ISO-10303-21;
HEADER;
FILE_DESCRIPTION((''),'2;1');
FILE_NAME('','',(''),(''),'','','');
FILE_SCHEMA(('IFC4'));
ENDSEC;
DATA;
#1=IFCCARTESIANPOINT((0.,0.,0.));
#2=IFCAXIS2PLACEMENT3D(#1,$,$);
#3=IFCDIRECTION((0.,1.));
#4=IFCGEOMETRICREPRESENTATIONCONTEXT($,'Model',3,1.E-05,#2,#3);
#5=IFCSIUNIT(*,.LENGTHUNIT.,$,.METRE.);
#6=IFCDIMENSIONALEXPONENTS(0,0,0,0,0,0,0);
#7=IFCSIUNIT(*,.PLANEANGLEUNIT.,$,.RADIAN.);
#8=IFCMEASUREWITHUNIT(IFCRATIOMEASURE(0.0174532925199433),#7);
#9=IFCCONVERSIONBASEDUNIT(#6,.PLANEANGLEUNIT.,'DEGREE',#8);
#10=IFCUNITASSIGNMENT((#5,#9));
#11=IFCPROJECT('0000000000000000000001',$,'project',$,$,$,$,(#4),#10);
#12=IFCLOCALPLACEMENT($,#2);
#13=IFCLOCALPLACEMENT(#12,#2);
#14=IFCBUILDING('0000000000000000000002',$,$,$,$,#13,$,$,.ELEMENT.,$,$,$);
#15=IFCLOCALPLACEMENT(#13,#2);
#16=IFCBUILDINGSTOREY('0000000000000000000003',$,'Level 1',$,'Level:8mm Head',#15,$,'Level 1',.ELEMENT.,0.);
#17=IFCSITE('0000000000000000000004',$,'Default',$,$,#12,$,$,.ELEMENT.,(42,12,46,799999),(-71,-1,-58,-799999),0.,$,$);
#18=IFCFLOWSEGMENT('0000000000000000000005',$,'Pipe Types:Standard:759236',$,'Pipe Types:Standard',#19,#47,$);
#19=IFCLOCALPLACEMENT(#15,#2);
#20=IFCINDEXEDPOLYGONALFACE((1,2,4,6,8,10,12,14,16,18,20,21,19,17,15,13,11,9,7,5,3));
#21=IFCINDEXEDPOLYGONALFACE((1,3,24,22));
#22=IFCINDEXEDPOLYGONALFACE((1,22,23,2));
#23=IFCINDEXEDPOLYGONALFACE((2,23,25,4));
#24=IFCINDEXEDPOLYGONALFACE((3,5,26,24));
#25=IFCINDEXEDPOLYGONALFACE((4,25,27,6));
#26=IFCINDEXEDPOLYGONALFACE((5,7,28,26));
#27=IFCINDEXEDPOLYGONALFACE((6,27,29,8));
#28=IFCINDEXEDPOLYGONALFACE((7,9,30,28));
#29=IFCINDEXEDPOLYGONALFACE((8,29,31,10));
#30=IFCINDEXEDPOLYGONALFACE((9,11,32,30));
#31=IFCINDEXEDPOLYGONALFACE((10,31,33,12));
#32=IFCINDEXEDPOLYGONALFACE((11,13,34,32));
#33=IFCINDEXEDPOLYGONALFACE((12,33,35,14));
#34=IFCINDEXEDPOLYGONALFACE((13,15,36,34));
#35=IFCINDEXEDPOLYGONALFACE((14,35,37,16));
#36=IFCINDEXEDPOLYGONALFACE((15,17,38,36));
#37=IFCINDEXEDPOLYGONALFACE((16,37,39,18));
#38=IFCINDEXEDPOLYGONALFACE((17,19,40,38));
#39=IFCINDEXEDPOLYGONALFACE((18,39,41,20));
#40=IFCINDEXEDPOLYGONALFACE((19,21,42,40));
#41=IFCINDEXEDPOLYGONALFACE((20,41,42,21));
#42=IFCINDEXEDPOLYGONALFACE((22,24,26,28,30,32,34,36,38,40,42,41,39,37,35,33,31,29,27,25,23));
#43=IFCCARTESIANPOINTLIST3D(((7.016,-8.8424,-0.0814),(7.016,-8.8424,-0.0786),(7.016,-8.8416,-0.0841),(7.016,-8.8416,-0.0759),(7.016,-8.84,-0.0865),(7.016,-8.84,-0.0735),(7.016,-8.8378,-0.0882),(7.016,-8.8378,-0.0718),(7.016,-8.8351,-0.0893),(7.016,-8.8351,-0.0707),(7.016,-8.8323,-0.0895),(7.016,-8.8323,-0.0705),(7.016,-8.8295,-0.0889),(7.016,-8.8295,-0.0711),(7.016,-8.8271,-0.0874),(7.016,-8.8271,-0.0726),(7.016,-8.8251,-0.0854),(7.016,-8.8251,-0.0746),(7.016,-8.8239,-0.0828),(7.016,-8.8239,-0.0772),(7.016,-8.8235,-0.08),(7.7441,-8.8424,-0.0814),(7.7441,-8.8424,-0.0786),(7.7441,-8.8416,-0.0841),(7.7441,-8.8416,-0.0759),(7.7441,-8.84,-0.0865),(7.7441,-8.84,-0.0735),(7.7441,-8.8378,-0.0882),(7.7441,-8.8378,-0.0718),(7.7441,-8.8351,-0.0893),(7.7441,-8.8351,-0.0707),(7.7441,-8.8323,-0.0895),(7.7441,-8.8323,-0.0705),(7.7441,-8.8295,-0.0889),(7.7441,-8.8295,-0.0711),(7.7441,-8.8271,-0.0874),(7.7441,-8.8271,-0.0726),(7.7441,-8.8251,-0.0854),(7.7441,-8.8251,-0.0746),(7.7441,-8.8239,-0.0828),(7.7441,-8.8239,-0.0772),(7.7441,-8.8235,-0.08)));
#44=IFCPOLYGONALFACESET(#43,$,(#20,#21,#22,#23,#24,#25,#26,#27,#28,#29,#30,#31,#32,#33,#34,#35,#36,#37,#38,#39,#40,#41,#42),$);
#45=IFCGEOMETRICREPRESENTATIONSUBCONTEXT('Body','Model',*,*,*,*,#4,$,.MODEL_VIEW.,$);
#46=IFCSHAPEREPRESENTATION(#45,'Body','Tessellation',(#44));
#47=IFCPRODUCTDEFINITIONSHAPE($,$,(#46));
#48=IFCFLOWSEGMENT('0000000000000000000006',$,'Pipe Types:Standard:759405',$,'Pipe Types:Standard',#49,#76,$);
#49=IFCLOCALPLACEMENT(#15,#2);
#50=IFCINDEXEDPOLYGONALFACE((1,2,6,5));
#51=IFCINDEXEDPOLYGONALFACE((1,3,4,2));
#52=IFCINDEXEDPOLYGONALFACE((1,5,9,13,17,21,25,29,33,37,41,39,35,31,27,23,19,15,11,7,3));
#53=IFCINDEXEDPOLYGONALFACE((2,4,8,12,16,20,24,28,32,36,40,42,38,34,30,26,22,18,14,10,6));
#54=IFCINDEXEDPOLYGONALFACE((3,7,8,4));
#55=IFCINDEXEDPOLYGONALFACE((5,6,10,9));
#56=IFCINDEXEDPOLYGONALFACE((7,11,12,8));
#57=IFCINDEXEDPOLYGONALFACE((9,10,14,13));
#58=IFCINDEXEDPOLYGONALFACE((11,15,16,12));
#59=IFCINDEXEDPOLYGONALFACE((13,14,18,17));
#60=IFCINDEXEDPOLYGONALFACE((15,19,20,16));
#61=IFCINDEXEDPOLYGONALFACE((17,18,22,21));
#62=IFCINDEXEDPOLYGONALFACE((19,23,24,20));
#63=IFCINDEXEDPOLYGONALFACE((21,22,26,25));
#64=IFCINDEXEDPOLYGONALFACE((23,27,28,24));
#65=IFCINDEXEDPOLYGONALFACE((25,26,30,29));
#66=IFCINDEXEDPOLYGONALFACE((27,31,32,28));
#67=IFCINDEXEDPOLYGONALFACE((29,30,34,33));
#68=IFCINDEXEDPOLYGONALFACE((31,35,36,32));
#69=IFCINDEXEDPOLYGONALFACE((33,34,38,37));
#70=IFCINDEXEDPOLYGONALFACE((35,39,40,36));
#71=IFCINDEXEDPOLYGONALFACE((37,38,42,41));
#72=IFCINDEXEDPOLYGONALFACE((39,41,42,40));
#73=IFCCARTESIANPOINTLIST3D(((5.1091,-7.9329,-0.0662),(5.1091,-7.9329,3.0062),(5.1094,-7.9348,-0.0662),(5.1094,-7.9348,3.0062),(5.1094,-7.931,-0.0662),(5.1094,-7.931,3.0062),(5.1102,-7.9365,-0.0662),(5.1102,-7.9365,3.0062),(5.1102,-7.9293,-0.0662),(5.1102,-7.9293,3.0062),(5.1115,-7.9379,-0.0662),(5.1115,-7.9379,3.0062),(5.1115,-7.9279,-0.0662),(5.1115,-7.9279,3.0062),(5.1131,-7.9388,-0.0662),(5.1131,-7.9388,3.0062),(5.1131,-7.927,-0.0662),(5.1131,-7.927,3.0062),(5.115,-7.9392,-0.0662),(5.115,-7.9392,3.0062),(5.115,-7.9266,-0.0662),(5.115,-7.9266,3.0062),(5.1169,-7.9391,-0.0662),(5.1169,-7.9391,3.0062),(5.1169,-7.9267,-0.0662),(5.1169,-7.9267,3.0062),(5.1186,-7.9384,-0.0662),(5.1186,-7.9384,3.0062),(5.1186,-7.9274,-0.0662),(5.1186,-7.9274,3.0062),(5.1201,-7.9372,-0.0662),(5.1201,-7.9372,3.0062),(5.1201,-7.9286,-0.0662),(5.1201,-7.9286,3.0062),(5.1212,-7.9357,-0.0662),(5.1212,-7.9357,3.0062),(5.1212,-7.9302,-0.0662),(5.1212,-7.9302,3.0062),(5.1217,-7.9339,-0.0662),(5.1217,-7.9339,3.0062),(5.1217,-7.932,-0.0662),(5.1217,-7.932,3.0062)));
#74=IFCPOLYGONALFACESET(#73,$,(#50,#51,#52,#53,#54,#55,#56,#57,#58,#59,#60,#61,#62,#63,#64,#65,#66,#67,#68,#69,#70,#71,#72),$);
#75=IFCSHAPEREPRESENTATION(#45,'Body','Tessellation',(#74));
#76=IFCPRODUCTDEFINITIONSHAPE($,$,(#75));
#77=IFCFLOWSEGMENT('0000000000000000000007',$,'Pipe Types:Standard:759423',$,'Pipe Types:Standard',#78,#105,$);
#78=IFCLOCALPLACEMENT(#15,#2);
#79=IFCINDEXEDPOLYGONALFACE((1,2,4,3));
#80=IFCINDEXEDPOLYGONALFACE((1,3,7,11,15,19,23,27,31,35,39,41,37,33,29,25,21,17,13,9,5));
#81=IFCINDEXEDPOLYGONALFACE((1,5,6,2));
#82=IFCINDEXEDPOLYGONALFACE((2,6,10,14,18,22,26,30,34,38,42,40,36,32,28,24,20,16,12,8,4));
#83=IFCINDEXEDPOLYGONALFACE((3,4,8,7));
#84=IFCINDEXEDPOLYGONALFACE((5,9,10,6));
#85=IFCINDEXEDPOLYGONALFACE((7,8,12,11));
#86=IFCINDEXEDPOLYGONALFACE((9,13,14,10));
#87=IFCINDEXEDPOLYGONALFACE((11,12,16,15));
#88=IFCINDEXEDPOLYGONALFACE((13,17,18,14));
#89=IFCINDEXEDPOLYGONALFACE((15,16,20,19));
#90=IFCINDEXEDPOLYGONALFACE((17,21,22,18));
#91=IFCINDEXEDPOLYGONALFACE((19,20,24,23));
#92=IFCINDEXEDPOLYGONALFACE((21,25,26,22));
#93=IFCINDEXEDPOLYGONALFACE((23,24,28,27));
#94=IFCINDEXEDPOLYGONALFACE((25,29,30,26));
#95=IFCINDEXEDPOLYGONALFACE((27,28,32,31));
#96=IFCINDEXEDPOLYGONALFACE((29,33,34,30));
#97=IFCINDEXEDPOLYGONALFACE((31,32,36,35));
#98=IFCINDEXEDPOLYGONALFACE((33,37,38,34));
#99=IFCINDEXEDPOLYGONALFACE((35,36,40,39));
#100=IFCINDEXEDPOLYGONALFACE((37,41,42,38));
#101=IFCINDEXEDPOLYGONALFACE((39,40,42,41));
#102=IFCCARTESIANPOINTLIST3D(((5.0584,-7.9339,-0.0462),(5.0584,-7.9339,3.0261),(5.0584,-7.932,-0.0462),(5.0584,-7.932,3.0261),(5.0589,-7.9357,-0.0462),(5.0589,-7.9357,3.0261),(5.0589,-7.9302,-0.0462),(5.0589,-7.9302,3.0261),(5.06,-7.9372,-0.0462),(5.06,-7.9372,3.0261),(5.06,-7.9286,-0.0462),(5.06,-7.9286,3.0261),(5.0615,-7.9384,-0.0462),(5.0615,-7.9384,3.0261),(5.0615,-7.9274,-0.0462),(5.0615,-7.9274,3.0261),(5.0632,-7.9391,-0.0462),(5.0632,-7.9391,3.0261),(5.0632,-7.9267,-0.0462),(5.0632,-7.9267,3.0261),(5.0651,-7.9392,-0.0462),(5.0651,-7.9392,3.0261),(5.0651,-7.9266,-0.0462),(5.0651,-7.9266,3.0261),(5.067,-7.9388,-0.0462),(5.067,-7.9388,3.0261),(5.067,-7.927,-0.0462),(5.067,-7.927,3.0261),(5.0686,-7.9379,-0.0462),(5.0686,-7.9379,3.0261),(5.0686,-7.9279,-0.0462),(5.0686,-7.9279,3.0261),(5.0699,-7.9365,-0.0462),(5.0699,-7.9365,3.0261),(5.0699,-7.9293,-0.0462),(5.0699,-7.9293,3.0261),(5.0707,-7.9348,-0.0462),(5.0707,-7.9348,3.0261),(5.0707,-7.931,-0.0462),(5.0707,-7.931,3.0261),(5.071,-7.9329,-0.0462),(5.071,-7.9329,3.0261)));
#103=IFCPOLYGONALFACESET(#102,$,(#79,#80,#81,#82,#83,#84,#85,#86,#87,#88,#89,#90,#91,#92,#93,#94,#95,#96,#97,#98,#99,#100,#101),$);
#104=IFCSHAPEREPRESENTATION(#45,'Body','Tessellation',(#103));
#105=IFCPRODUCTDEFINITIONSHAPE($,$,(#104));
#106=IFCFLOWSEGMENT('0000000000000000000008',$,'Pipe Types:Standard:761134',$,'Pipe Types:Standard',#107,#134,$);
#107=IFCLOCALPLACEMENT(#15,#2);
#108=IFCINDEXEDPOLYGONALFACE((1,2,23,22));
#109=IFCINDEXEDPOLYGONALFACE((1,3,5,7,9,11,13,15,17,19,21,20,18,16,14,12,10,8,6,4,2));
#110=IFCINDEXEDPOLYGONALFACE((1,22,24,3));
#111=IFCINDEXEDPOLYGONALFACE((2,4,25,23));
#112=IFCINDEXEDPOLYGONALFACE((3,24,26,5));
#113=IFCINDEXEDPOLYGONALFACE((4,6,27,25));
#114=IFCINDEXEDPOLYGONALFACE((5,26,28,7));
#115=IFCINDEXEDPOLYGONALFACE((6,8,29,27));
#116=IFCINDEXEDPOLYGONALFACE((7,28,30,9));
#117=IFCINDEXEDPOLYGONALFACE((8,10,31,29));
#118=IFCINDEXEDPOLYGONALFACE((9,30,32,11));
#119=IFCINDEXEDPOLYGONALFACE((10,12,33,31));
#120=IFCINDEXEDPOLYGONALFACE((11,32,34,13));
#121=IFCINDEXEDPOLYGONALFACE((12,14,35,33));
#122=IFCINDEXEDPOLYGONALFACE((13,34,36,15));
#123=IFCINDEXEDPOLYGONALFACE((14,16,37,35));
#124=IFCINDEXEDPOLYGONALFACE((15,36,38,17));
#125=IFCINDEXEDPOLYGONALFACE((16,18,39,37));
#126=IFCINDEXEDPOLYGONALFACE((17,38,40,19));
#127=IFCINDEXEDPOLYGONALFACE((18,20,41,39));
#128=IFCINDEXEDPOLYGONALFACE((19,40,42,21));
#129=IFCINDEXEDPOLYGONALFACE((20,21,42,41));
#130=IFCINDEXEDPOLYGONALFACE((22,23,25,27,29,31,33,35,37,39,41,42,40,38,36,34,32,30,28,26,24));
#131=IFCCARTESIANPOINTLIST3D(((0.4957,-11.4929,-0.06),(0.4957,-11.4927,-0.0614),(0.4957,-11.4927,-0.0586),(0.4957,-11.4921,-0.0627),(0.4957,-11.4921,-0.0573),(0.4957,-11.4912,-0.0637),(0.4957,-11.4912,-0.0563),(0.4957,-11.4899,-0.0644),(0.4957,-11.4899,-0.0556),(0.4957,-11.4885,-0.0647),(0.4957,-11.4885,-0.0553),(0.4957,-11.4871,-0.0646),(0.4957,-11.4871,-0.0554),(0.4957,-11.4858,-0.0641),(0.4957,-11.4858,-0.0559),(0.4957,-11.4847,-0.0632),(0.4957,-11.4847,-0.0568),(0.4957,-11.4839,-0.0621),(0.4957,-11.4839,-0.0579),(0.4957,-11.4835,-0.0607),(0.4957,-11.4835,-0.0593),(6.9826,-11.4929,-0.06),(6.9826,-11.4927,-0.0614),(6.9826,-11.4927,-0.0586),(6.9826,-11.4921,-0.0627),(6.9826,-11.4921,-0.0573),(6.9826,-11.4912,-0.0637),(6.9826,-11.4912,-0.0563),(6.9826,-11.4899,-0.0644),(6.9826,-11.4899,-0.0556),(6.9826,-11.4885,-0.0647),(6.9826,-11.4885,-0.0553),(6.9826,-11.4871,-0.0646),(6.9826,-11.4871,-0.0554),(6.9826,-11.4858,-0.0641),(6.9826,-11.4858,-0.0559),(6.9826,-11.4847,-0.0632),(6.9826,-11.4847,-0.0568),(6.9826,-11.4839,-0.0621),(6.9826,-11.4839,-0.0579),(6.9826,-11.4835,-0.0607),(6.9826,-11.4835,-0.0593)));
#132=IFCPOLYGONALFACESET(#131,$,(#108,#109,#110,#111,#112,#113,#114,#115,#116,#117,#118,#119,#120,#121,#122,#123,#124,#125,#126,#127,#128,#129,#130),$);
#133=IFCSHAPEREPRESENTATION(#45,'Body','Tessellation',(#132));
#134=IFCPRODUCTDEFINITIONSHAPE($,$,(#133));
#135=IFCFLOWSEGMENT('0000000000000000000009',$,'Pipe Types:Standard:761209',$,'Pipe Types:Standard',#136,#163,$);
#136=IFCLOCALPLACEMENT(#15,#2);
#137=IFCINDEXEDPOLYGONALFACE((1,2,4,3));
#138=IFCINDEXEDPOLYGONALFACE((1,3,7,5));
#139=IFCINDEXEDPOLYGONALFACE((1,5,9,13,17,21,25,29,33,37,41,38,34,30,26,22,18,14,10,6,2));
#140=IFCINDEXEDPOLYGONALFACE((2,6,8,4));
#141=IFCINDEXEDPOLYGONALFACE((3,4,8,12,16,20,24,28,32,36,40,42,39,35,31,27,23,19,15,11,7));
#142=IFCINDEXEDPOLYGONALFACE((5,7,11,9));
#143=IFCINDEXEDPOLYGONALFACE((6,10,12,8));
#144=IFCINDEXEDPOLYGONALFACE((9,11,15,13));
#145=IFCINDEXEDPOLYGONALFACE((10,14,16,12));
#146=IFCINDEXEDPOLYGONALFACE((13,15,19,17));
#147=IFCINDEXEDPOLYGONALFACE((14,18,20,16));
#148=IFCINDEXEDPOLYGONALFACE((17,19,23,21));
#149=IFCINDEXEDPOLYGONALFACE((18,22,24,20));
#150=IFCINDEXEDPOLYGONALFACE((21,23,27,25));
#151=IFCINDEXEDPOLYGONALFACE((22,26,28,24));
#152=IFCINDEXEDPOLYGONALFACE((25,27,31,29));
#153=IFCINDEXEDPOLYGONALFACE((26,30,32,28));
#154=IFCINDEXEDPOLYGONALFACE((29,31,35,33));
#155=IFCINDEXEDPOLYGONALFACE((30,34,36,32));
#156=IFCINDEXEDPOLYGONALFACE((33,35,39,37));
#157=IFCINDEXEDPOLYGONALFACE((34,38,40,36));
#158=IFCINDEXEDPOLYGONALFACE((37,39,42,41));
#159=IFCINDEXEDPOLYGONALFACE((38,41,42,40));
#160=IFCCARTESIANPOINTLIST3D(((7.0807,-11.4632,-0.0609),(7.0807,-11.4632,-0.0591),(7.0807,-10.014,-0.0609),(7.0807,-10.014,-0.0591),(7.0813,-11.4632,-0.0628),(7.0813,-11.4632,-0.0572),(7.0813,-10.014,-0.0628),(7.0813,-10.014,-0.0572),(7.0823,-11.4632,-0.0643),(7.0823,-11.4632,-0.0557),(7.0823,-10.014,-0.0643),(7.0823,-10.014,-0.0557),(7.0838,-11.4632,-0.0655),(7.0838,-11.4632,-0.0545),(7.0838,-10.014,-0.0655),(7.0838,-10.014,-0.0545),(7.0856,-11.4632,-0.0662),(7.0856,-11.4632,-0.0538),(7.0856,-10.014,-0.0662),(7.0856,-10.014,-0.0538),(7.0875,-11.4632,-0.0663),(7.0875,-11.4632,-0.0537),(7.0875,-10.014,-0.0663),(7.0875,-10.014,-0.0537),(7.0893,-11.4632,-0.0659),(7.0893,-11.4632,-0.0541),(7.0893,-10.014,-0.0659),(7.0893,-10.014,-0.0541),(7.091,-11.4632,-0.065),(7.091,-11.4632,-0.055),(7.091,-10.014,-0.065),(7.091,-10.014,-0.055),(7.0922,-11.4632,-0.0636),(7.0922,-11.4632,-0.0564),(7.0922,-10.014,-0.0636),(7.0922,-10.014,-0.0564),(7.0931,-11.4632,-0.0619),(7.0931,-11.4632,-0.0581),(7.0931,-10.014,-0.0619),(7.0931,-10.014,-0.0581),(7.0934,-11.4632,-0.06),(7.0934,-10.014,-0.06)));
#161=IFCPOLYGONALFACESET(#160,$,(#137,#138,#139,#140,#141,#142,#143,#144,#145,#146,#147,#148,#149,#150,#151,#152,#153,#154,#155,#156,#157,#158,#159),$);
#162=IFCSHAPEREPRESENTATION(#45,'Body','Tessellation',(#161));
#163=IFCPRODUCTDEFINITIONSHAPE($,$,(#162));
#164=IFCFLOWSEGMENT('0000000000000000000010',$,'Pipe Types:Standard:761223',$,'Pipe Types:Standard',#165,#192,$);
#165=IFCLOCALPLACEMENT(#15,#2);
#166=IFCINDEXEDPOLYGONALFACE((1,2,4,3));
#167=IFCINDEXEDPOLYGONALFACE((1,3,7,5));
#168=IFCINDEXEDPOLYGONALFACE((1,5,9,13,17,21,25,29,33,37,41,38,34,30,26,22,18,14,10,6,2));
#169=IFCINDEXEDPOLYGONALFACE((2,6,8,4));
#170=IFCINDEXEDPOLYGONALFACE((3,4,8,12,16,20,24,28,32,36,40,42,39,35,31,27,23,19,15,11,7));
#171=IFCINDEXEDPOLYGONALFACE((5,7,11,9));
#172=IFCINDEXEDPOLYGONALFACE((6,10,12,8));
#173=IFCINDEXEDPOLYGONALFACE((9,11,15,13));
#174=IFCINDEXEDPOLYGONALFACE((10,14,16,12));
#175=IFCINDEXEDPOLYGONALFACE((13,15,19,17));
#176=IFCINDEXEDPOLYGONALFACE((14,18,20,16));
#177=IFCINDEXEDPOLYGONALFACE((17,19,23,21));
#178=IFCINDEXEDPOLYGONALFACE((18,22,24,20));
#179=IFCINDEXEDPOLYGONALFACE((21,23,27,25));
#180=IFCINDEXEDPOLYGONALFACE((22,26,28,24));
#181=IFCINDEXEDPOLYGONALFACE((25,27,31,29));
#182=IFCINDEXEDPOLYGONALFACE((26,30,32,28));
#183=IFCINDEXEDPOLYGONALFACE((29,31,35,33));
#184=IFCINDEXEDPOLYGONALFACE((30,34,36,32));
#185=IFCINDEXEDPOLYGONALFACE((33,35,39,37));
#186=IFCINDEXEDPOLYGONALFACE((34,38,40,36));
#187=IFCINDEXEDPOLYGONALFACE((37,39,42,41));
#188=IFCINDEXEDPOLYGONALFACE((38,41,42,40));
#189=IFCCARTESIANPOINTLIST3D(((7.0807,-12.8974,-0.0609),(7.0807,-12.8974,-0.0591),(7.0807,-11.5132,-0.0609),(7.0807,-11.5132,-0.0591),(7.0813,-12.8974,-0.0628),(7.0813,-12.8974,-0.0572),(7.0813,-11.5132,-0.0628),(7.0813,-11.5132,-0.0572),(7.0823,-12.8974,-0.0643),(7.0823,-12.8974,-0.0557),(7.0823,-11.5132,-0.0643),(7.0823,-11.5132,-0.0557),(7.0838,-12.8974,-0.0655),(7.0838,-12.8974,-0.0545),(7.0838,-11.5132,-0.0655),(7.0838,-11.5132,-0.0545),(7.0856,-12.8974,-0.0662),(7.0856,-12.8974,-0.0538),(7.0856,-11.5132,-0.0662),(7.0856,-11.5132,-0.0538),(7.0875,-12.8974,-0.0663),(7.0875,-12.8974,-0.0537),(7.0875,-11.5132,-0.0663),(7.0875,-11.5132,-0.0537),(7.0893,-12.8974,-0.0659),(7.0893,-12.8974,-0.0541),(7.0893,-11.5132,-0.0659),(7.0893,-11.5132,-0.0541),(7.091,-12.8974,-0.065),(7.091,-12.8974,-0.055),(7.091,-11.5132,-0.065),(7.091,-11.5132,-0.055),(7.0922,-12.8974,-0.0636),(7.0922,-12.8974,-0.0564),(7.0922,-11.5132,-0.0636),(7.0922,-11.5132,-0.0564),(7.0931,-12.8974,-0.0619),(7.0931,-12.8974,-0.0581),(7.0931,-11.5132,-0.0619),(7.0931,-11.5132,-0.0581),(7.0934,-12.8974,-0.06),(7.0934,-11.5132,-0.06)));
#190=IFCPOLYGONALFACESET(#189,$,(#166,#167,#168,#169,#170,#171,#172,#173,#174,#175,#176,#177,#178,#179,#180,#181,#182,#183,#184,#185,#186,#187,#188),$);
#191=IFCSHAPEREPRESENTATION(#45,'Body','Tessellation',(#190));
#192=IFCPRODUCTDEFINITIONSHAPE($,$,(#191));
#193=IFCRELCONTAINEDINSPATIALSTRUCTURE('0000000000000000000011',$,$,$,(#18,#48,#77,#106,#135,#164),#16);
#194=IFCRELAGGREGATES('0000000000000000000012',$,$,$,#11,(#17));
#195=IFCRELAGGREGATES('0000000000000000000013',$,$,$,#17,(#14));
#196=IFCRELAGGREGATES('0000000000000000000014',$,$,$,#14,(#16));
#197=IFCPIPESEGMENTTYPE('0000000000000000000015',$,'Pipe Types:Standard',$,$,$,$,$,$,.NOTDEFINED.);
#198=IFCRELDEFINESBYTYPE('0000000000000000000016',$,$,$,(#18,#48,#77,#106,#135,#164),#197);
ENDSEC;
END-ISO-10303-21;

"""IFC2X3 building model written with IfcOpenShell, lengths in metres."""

from ifc_helpers import new_model, entity, si_unit, converted_unit, direction, frame, frame_2d, origin, origin_2d_with_axis, place, context, subcontext, project, spatial, circle, extrude, type_object, element, save


model = new_model("IFC2X3")

# Units and contexts
model_context = context("Model", 3, precision=1e-05, world=origin(), true_north=direction((0.0, 1.0)))
body_context = subcontext(model_context, "Body", "Model", "MODEL_VIEW")
ifc_project = project(units=[si_unit("LENGTHUNIT", "METRE"), converted_unit("PLANEANGLEUNIT", "DEGREE", entity("IfcRatioMeasure", 0.0174532925199433), si_unit("PLANEANGLEUNIT", "RADIAN"), dimensions=[0, 0, 0, 0, 0, 0, 0])], contexts=[model_context])

# Site, building, storey
site_placement = place(None, origin())
site = spatial("IfcSite", under=ifc_project, at=site_placement, Name="Default", CompositionType="ELEMENT", RefLatitude=(42, 12, 46, 799999), RefLongitude=(-71, -1, -58, -799999), RefElevation=0.0)
building_placement = place(site_placement, origin())
building = spatial("IfcBuilding", under=site, at=building_placement, CompositionType="ELEMENT")
storey_placement = place(building_placement, origin())
storey = spatial("IfcBuildingStorey", under=building, at=storey_placement, Name="Level 1", ObjectType="Level:8mm Head", LongName="Level 1", CompositionType="ELEMENT", Elevation=0.0)

# Flow segments
pipe_segment_type = type_object("IfcPipeSegmentType", Name="Pipe Types:Standard", PredefinedType="NOTDEFINED")
flow_segment_1_placement = place(storey_placement, origin())
element("IfcFlowSegment", 1, at=flow_segment_1_placement, inside=storey, type_object=pipe_segment_type, Name="Pipe Types:Standard:759236", ObjectType="Pipe Types:Standard", context=body_context, shape_type="SweptSolid", body=[
    extrude(circle(Radius=0.0095, at=frame_2d((0.0, 0.0), x_axis=(1.0, 0.0))), frame((7.016, -8.833, -0.08), z_axis=(1.0, 0.0, 0.0), x_axis=(0.0, 1.0, 0.0)), (0.0, 0.0, 1.0), 0.7281),
])
flow_segment_2_placement = place(storey_placement, origin())
element("IfcFlowSegment", 2, at=flow_segment_2_placement, inside=storey, type_object=pipe_segment_type, Name="Pipe Types:Standard:759405", ObjectType="Pipe Types:Standard", context=body_context, shape_type="SweptSolid", body=[
    extrude(circle(Radius=0.0063, at=frame_2d((0.0, 0.0), x_axis=(1.0, 0.0))), frame((5.1155, -7.9329, -0.0662), z_axis=(0.0, 0.0, 1.0), x_axis=(-1.0, 0.0, 0.0)), (0.0, 0.0, 1.0), 3.0724),
])
flow_segment_3_placement = place(storey_placement, origin())
element("IfcFlowSegment", 3, at=flow_segment_3_placement, inside=storey, type_object=pipe_segment_type, Name="Pipe Types:Standard:759423", ObjectType="Pipe Types:Standard", context=body_context, shape_type="SweptSolid", body=[
    extrude(circle(Radius=0.0063, at=origin_2d_with_axis()), frame((5.0647, -7.9329, -0.0462)), (0.0, 0.0, 1.0), 3.0723),
])
flow_segment_4_placement = place(storey_placement, origin())
element("IfcFlowSegment", 4, at=flow_segment_4_placement, inside=storey, type_object=pipe_segment_type, Name="Pipe Types:Standard:761134", ObjectType="Pipe Types:Standard", context=body_context, shape_type="SweptSolid", body=[
    extrude(circle(Radius=0.0048, at=frame_2d((0.0, 0.0), x_axis=(1.0, 0.0))), frame((0.4957, -11.4882, -0.06), z_axis=(1.0, 0.0, 0.0), x_axis=(0.0, -1.0, 0.0)), (0.0, 0.0, 1.0), 6.4868),
])
flow_segment_5_placement = place(storey_placement, origin())
element("IfcFlowSegment", 5, at=flow_segment_5_placement, inside=storey, type_object=pipe_segment_type, Name="Pipe Types:Standard:761209", ObjectType="Pipe Types:Standard", context=body_context, shape_type="SweptSolid", body=[
    extrude(circle(Radius=0.0063, at=frame_2d((0.0, 0.0), x_axis=(1.0, 0.0))), frame((7.087, -11.4632, -0.06), z_axis=(0.0, 1.0, 0.0), x_axis=(1.0, 0.0, 0.0)), (0.0, 0.0, 1.0), 1.4492),
])
flow_segment_6_placement = place(storey_placement, origin())
element("IfcFlowSegment", 6, at=flow_segment_6_placement, inside=storey, type_object=pipe_segment_type, Name="Pipe Types:Standard:761223", ObjectType="Pipe Types:Standard", context=body_context, shape_type="SweptSolid", body=[
    extrude(circle(Radius=0.0063, at=frame_2d((0.0, 0.0), x_axis=(1.0, 0.0))), frame((7.087, -12.8974, -0.06), z_axis=(0.0, 1.0, 0.0), x_axis=(1.0, 0.0, 0.0)), (0.0, 0.0, 1.0), 1.3842),
])

save(model, "model.ifc")
